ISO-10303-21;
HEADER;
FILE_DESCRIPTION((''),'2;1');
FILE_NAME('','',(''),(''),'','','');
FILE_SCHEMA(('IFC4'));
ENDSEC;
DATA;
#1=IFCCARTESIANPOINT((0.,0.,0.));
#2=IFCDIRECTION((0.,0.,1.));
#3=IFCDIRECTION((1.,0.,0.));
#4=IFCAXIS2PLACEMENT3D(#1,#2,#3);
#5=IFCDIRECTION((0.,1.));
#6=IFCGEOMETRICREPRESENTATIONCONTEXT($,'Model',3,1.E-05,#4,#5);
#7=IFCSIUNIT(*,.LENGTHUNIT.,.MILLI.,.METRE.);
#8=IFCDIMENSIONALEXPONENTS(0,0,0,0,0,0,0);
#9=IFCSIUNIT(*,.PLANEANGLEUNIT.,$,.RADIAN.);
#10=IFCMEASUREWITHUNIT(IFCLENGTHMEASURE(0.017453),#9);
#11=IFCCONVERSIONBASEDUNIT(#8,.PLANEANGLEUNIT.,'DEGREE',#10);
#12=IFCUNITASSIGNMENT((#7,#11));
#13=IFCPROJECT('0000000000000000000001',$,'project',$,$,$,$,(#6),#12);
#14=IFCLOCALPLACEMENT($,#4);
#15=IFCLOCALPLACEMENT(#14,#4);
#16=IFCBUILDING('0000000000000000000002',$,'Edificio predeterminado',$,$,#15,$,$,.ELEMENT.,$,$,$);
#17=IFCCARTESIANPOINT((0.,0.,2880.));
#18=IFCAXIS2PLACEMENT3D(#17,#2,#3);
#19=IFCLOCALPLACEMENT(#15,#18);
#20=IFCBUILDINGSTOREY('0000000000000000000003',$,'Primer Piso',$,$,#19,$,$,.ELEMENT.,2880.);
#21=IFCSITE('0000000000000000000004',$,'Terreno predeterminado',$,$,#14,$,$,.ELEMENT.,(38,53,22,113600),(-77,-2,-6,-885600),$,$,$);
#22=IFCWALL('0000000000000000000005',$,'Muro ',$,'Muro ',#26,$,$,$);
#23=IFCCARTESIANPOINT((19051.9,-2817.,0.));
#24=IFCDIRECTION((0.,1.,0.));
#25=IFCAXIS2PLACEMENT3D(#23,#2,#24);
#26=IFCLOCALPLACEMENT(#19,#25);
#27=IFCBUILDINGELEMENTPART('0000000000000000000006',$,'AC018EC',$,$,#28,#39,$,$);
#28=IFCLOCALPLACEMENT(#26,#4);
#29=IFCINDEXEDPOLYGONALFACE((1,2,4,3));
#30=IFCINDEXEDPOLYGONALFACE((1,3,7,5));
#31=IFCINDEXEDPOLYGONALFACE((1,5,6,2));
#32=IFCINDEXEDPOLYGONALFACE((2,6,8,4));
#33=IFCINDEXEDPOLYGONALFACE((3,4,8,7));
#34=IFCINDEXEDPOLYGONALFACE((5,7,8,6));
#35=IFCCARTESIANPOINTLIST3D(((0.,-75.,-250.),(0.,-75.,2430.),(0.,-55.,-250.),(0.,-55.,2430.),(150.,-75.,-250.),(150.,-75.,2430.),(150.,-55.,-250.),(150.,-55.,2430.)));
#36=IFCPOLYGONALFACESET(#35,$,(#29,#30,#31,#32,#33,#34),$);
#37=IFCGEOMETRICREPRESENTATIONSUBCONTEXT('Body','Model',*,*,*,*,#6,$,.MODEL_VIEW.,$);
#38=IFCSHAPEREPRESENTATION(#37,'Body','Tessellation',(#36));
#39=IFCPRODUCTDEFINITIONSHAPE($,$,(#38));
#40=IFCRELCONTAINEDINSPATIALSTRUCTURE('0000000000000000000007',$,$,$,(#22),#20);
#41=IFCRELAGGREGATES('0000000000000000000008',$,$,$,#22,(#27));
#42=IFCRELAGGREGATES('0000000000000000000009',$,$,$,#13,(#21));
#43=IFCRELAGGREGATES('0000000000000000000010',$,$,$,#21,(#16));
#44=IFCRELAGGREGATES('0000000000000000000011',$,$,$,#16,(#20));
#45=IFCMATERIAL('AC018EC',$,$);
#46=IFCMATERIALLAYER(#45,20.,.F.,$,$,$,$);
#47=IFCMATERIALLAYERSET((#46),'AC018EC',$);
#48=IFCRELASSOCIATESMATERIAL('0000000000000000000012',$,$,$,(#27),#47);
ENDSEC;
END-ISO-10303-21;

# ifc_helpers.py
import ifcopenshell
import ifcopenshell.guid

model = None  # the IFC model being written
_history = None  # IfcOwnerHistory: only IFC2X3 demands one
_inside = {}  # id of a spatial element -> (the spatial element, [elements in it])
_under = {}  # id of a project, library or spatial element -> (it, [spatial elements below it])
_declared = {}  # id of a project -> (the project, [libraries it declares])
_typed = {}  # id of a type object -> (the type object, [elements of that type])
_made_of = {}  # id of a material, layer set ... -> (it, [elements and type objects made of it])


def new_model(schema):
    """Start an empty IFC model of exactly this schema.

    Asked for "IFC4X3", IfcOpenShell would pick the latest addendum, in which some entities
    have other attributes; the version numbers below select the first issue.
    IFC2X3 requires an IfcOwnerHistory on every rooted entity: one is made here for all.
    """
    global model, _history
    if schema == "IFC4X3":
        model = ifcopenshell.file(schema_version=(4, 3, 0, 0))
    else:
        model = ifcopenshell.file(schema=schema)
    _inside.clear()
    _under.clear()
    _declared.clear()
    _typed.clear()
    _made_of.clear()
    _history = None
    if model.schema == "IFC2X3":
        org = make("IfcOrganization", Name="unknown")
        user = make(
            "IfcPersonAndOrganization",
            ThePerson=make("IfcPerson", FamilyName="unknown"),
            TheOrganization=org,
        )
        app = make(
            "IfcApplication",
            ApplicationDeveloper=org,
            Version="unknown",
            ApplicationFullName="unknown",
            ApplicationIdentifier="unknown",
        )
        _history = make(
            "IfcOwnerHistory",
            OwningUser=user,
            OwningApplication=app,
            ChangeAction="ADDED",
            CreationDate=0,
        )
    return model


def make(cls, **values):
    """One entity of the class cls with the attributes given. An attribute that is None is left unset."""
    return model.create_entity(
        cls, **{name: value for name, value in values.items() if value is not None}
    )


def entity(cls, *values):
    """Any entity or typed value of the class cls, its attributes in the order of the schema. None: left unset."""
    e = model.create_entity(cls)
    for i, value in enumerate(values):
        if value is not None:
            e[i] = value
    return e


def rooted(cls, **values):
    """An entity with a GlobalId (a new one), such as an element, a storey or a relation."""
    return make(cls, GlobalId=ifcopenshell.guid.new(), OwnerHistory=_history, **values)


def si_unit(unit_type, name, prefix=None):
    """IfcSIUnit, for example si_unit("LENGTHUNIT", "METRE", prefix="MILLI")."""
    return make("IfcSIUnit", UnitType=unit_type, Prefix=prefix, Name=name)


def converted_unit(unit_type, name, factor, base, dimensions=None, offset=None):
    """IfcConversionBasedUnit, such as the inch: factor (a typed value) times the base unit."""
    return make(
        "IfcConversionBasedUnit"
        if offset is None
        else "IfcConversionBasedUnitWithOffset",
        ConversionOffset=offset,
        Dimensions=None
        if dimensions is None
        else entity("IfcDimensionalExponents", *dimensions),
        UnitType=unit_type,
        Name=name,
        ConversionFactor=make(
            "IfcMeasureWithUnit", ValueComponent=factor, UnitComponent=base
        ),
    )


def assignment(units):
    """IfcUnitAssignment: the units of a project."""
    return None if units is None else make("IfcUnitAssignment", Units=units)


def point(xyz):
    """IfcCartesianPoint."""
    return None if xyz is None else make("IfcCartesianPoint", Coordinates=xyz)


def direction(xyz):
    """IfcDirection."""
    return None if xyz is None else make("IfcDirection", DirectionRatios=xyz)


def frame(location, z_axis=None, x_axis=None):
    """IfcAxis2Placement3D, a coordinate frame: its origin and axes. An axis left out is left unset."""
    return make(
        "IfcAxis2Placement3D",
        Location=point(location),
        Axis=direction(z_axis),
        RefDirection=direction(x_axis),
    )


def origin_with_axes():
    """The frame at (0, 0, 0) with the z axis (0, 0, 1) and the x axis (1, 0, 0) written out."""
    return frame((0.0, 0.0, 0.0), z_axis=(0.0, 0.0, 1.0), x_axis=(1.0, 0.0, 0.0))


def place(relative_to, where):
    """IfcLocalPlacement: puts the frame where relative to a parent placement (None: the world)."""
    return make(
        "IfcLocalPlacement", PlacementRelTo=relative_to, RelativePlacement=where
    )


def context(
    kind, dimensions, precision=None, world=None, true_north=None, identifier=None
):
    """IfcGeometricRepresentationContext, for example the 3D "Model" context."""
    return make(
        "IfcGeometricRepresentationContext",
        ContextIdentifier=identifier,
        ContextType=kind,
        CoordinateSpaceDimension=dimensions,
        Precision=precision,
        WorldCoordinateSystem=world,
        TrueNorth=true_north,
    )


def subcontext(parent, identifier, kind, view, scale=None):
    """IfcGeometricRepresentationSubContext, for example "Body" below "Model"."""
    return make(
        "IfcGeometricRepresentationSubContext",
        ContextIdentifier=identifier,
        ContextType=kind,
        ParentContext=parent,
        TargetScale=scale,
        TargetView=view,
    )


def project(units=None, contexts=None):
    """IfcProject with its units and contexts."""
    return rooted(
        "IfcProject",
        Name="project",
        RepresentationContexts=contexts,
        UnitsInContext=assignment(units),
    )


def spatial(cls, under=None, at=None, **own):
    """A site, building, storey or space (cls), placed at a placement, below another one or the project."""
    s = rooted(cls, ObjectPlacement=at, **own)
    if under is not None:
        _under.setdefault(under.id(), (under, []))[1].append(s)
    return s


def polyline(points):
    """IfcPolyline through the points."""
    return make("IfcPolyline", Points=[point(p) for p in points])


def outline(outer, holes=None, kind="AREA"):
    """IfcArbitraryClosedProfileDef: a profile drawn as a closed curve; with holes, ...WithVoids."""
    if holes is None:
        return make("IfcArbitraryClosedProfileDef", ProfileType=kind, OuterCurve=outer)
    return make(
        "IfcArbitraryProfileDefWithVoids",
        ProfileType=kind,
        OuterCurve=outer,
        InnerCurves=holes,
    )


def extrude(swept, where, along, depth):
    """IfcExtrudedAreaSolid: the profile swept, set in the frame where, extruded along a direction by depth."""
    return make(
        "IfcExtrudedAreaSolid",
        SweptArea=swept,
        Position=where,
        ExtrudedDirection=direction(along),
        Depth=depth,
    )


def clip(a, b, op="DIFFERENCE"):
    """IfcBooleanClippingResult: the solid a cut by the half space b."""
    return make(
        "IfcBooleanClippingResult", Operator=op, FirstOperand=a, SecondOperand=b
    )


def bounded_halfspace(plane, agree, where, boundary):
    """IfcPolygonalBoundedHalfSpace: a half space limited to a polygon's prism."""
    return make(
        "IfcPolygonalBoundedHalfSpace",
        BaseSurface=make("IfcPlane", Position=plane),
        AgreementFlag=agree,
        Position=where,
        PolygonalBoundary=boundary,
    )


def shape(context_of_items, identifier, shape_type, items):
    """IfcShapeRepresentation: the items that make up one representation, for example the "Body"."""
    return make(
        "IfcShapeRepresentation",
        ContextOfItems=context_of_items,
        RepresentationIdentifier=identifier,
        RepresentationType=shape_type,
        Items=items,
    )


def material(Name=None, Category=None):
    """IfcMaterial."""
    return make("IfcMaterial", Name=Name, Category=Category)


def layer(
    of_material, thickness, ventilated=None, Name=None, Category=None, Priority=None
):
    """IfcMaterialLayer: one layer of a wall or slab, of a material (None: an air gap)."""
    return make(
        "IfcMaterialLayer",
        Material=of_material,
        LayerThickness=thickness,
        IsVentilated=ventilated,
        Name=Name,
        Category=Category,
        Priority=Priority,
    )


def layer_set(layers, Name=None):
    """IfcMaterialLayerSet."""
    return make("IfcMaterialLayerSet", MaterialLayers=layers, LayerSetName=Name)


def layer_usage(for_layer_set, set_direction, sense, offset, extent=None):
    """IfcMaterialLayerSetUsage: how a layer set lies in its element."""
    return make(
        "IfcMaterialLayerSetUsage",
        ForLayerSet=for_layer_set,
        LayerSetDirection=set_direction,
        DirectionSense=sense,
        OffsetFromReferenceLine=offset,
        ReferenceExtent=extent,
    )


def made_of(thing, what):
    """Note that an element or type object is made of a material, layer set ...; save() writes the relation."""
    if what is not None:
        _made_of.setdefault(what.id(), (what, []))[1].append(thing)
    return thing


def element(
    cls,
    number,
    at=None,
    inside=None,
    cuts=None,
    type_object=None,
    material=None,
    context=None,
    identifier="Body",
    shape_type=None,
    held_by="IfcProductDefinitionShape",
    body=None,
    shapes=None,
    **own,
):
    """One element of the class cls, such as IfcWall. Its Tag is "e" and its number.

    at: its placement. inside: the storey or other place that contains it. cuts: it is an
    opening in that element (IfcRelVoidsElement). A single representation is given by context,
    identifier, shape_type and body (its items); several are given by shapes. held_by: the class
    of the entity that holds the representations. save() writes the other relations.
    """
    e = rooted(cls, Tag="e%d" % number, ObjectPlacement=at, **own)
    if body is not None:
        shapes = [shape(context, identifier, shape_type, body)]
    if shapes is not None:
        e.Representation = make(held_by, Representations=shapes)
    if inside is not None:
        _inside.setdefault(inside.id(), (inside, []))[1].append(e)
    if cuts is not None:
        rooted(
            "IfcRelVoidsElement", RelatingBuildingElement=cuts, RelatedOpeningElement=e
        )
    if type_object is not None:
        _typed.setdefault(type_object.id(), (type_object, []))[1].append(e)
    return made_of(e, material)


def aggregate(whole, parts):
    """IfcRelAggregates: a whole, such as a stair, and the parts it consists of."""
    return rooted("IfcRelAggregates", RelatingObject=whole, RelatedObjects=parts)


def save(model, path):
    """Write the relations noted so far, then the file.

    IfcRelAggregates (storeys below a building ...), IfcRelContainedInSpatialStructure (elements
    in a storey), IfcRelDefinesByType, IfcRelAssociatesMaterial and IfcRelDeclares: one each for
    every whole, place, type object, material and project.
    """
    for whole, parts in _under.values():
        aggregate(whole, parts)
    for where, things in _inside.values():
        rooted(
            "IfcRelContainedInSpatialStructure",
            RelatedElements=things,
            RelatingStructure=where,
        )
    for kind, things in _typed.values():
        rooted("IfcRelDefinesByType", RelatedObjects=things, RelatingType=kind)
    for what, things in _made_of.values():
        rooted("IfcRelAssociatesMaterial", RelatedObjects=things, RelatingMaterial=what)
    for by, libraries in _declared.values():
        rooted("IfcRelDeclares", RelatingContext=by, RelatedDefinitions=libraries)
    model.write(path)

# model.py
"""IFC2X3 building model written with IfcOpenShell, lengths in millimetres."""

from ifc_helpers import new_model, entity, si_unit, converted_unit, direction, frame, origin_with_axes, place, context, subcontext, project, spatial, polyline, outline, extrude, clip, bounded_halfspace, material, layer, layer_set, layer_usage, element, aggregate, save


model = new_model("IFC2X3")

# Units and contexts
model_context = context("Model", 3, precision=1e-05, world=origin_with_axes(), true_north=direction((0.0, 1.0)))
body_context = subcontext(model_context, "Body", "Model", "MODEL_VIEW")
ifc_project = project(units=[si_unit("LENGTHUNIT", "METRE", prefix="MILLI"), converted_unit("PLANEANGLEUNIT", "DEGREE", entity("IfcLengthMeasure", 0.017453), si_unit("PLANEANGLEUNIT", "RADIAN"), dimensions=[0, 0, 0, 0, 0, 0, 0])], contexts=[model_context])

# Site, building, storey
site_placement = place(None, origin_with_axes())
site = spatial("IfcSite", under=ifc_project, at=site_placement, Name="Terreno predeterminado", CompositionType="ELEMENT", RefLatitude=(38, 53, 22, 113600), RefLongitude=(-77, -2, -6, -885600))
building_placement = place(site_placement, origin_with_axes())
building = spatial("IfcBuilding", under=site, at=building_placement, Name="Edificio predeterminado", CompositionType="ELEMENT")
storey_placement = place(building_placement, frame((0.0, 0.0, 2880.0), z_axis=(0.0, 0.0, 1.0), x_axis=(1.0, 0.0, 0.0)))
storey = spatial("IfcBuildingStorey", under=building, at=storey_placement, Name="Primer Piso", CompositionType="ELEMENT", Elevation=2880.0)

# Wall, building element part
wall_1_placement = place(storey_placement, frame((19051.9, -2817.0, 0.0), z_axis=(0.0, 0.0, 1.0), x_axis=(0.0, 1.0, 0.0)))
wall_1 = element("IfcWall", 1, at=wall_1_placement, inside=storey, Name="Muro ", ObjectType="Muro ")
ifc_material_1 = material(Name="AC018EC")
ifc_layer_1 = layer(ifc_material_1, 20.0, ventilated=False)
ifc_layer_set_1 = layer_set([ifc_layer_1], Name="AC018EC")
ifc_layer_usage_1 = layer_usage(ifc_layer_set_1, "AXIS2", "NEGATIVE", 55.0)
building_element_part_1_placement = place(wall_1_placement, origin_with_axes())
building_element_part_1 = element("IfcBuildingElementPart", 2, at=building_element_part_1_placement, material=ifc_layer_usage_1, Name="AC018EC", context=body_context, shape_type="Clipping", body=[
    clip(clip(extrude(outline(polyline([(150.0, -55.0), (150.0, -75.0), (0.0, -75.0), (0.0, -55.0), (150.0, -55.0)])), frame((0.0, 0.0, -250.0), z_axis=(0.0, 0.0, 1.0), x_axis=(1.0, 0.0, 0.0)), (0.0, 0.0, 1.0), 2680.0), bounded_halfspace(frame((0.0, 0.0, -250.0), z_axis=(0.0, 0.0, 1.0), x_axis=(1.0, 0.0, 0.0)), True, origin_with_axes(), polyline([(-150.0, -150.0), (375.0, -150.0), (375.0, 150.0), (-150.0, 150.0), (-150.0, -150.0)]))), bounded_halfspace(frame((0.0, 0.0, 2430.0), z_axis=(0.0, 0.0, 1.0), x_axis=(1.0, 0.0, 0.0)), False, origin_with_axes(), polyline([(-150.0, -150.0), (375.0, -150.0), (375.0, 150.0), (-150.0, 150.0), (-150.0, -150.0)]))),
])
aggregate(wall_1, [building_element_part_1])

save(model, "model.ifc")
